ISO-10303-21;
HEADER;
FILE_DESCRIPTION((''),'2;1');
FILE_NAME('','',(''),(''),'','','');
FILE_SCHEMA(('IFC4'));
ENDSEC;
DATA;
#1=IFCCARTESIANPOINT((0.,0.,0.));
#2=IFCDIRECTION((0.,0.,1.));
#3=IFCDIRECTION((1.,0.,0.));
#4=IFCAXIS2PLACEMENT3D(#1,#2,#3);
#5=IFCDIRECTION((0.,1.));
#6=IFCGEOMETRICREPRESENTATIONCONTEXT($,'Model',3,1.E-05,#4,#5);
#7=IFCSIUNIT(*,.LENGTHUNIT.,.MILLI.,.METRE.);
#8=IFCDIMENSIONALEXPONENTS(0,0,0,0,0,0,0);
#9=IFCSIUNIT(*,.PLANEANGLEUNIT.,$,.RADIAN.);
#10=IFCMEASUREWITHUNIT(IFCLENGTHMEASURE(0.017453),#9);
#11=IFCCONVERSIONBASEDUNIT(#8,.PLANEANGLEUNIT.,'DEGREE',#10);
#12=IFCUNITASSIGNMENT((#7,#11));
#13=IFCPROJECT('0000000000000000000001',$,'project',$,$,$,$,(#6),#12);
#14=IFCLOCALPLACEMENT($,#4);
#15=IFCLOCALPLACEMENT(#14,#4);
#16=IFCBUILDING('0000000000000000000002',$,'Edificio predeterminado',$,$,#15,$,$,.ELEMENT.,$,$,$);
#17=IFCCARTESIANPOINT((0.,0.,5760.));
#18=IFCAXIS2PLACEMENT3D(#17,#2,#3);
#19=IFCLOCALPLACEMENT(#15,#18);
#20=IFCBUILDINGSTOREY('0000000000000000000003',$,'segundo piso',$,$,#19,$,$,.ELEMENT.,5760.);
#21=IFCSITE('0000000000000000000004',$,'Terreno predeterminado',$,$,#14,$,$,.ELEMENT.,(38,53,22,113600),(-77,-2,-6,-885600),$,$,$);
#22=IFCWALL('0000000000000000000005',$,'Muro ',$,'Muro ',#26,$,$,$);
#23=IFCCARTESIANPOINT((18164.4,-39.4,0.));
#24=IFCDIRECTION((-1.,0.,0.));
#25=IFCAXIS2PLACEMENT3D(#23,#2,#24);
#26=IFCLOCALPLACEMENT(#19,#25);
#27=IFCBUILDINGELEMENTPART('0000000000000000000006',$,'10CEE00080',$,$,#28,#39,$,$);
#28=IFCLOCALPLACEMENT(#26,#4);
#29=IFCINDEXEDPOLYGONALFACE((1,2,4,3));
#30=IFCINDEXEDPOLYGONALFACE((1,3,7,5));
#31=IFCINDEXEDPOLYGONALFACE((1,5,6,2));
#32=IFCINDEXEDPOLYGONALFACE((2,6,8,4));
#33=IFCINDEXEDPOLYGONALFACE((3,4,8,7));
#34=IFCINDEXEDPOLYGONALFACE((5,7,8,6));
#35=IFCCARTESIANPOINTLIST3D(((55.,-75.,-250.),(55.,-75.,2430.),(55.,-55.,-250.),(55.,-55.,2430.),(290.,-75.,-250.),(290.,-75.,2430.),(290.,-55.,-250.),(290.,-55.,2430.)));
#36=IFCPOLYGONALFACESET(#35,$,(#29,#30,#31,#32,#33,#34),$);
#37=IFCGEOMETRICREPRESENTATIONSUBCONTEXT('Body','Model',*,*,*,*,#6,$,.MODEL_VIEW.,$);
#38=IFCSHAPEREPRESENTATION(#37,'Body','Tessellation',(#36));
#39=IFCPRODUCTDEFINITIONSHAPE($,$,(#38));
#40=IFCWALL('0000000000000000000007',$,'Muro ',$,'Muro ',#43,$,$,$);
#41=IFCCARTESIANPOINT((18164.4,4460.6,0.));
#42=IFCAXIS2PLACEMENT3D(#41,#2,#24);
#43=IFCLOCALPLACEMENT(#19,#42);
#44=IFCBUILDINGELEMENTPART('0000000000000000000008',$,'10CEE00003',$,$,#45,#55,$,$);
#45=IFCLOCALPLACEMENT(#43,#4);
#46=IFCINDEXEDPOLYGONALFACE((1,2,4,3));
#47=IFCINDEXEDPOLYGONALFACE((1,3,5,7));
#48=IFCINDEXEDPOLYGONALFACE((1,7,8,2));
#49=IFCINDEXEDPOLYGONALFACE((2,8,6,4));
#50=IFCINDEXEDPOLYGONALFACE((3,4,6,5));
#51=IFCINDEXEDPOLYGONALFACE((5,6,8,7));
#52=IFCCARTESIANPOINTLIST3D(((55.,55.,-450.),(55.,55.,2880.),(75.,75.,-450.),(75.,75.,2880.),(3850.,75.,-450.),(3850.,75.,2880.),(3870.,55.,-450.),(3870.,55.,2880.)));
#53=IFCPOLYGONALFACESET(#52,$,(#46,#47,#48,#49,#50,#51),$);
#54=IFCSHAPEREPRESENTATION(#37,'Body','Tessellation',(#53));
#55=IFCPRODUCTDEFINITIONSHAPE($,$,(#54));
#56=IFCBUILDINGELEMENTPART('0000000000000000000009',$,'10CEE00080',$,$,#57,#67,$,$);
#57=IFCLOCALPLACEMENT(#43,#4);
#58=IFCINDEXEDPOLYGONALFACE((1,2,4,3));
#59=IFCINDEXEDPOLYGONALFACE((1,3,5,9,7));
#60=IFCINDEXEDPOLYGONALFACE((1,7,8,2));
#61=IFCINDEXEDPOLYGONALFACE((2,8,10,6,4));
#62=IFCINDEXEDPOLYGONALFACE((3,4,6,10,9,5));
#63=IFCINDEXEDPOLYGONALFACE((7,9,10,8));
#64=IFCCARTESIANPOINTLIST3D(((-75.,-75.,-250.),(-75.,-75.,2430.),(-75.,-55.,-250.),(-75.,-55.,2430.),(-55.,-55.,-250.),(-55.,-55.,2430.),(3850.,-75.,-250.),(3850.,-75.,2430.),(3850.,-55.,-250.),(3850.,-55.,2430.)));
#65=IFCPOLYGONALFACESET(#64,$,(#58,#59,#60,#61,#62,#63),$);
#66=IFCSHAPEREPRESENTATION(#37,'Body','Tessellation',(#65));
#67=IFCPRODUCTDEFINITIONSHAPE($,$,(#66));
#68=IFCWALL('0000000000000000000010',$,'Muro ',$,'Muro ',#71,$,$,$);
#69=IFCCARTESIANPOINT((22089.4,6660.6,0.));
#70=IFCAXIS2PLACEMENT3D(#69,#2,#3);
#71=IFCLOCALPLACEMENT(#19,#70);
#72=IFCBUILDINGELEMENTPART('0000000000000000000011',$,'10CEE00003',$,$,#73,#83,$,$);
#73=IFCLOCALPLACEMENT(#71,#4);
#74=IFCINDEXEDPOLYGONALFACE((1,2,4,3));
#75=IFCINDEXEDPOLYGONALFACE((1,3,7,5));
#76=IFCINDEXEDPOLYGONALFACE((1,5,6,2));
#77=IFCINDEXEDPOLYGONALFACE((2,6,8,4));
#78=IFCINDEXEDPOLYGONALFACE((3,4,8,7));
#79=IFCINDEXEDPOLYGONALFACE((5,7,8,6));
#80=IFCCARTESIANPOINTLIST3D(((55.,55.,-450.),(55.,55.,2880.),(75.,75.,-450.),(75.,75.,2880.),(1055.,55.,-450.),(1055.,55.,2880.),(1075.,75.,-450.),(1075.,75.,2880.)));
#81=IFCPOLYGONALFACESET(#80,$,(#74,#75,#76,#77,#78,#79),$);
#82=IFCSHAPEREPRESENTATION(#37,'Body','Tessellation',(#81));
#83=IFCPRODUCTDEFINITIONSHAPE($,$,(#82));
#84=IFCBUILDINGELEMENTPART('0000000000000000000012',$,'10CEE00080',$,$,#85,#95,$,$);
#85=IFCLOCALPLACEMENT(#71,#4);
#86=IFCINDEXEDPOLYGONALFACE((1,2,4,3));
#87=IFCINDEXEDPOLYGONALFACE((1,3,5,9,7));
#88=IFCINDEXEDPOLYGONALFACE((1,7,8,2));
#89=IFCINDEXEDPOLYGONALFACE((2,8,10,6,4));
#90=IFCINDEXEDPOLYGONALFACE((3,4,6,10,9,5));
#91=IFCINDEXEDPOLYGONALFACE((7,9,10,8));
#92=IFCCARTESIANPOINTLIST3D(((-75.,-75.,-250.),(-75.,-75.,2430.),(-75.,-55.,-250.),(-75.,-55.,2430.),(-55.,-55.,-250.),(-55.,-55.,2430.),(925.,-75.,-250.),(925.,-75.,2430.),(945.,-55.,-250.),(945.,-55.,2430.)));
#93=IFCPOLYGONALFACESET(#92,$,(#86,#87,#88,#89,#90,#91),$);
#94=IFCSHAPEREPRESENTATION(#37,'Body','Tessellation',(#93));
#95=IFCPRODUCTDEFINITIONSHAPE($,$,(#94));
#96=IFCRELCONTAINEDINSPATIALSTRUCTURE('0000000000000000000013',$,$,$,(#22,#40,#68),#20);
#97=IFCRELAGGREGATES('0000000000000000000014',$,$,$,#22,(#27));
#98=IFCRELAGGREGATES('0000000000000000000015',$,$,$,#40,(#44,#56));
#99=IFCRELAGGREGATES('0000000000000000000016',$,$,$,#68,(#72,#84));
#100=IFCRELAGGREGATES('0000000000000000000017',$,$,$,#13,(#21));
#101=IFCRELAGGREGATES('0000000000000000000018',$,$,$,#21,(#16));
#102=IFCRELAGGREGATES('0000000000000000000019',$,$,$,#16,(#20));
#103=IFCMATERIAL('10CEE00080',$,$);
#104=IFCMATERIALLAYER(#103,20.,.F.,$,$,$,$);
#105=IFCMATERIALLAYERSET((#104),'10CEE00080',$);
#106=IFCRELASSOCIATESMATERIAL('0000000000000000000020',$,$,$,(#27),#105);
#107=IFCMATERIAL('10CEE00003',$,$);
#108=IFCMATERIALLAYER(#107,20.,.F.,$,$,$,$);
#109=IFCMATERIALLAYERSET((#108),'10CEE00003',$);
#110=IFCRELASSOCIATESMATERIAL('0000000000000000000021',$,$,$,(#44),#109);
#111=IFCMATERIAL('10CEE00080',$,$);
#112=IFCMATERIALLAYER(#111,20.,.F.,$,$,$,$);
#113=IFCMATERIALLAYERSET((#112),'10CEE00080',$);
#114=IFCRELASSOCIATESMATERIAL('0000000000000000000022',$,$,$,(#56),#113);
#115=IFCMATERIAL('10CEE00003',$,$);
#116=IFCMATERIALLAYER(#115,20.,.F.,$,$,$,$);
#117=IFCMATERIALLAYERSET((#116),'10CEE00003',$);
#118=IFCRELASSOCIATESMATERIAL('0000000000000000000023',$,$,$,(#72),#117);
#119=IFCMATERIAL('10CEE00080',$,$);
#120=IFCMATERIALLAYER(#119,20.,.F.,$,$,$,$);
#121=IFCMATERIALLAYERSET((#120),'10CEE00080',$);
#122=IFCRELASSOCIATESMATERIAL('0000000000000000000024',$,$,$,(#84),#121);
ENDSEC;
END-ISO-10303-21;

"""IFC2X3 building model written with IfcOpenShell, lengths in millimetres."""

from ifc_helpers import new_model, entity, si_unit, converted_unit, direction, frame, origin_with_axes, place, context, subcontext, project, spatial, polyline, outline, extrude, material, layer, layer_set, layer_usage, element, aggregate, save


model = new_model("IFC2X3")

# Units and contexts
model_context = context("Model", 3, precision=1e-05, world=origin_with_axes(), true_north=direction((0.0, 1.0)))
body_context = subcontext(model_context, "Body", "Model", "MODEL_VIEW")
ifc_project = project(units=[si_unit("LENGTHUNIT", "METRE", prefix="MILLI"), converted_unit("PLANEANGLEUNIT", "DEGREE", entity("IfcLengthMeasure", 0.017453), si_unit("PLANEANGLEUNIT", "RADIAN"), dimensions=[0, 0, 0, 0, 0, 0, 0])], contexts=[model_context])

# Site, building, storey
site_placement = place(None, origin_with_axes())
site = spatial("IfcSite", under=ifc_project, at=site_placement, Name="Terreno predeterminado", CompositionType="ELEMENT", RefLatitude=(38, 53, 22, 113600), RefLongitude=(-77, -2, -6, -885600))
building_placement = place(site_placement, origin_with_axes())
building = spatial("IfcBuilding", under=site, at=building_placement, Name="Edificio predeterminado", CompositionType="ELEMENT")
storey_placement = place(building_placement, frame((0.0, 0.0, 5760.0), z_axis=(0.0, 0.0, 1.0), x_axis=(1.0, 0.0, 0.0)))
storey = spatial("IfcBuildingStorey", under=building, at=storey_placement, Name="segundo piso", CompositionType="ELEMENT", Elevation=5760.0)

# Wall, building element part
wall_1_placement = place(storey_placement, frame((18164.4, -39.4, 0.0), z_axis=(0.0, 0.0, 1.0), x_axis=(-1.0, 0.0, 0.0)))
wall_1 = element("IfcWall", 1, at=wall_1_placement, inside=storey, Name="Muro ", ObjectType="Muro ")
ifc_material_1 = material(Name="10CEE00080")
ifc_layer_1 = layer(ifc_material_1, 20.0, ventilated=False)
ifc_layer_set_1 = layer_set([ifc_layer_1], Name="10CEE00080")
ifc_layer_usage_1 = layer_usage(ifc_layer_set_1, "AXIS2", "NEGATIVE", 55.0)
building_element_part_1_placement = place(wall_1_placement, origin_with_axes())
building_element_part_1 = element("IfcBuildingElementPart", 2, at=building_element_part_1_placement, material=ifc_layer_usage_1, Name="10CEE00080", context=body_context, shape_type="SweptSolid", body=[
    extrude(outline(polyline([(290.0, -55.0), (290.0, -75.0), (55.0, -75.0), (55.0, -55.0), (290.0, -55.0)])), frame((0.0, 0.0, -250.0), z_axis=(0.0, 0.0, 1.0), x_axis=(1.0, 0.0, 0.0)), (0.0, 0.0, 1.0), 2680.0),
])
aggregate(wall_1, [building_element_part_1])

# Walls, building element parts
wall_2_placement = place(storey_placement, frame((18164.4, 4460.6, 0.0), z_axis=(0.0, 0.0, 1.0), x_axis=(-1.0, 0.0, 0.0)))
wall_2 = element("IfcWall", 3, at=wall_2_placement, inside=storey, Name="Muro ", ObjectType="Muro ")
ifc_material_2 = material(Name="10CEE00003")
ifc_layer_2 = layer(ifc_material_2, 20.0, ventilated=False)
ifc_layer_set_2 = layer_set([ifc_layer_2], Name="10CEE00003")
ifc_layer_usage_2 = layer_usage(ifc_layer_set_2, "AXIS2", "NEGATIVE", -75.0)
building_element_part_2_placement = place(wall_2_placement, origin_with_axes())
building_element_part_2 = element("IfcBuildingElementPart", 4, at=building_element_part_2_placement, material=ifc_layer_usage_2, Name="10CEE00003", context=body_context, shape_type="SweptSolid", body=[
    extrude(outline(polyline([(3850.0, 75.0), (3870.0, 55.0), (55.0, 55.0), (75.0, 75.0), (3850.0, 75.0)])), frame((0.0, 0.0, -450.0), z_axis=(0.0, 0.0, 1.0), x_axis=(1.0, 0.0, 0.0)), (0.0, 0.0, 1.0), 3330.0),
])
ifc_material_3 = material(Name="10CEE00080")
ifc_layer_3 = layer(ifc_material_3, 20.0, ventilated=False)
ifc_layer_set_3 = layer_set([ifc_layer_3], Name="10CEE00080")
ifc_layer_usage_3 = layer_usage(ifc_layer_set_3, "AXIS2", "NEGATIVE", 55.0)
building_element_part_3_placement = place(wall_2_placement, origin_with_axes())
building_element_part_3 = element("IfcBuildingElementPart", 5, at=building_element_part_3_placement, material=ifc_layer_usage_3, Name="10CEE00080", context=body_context, shape_type="SweptSolid", body=[
    extrude(outline(polyline([(3850.0, -55.0), (3850.0, -75.0), (-75.0, -75.0), (-75.0, -55.0), (-55.0, -55.0), (3850.0, -55.0)])), frame((0.0, 0.0, -250.0), z_axis=(0.0, 0.0, 1.0), x_axis=(1.0, 0.0, 0.0)), (0.0, 0.0, 1.0), 2680.0),
])
aggregate(wall_2, [building_element_part_2, building_element_part_3])
wall_3_placement = place(storey_placement, frame((22089.4, 6660.6, 0.0), z_axis=(0.0, 0.0, 1.0), x_axis=(1.0, 0.0, 0.0)))
wall_3 = element("IfcWall", 6, at=wall_3_placement, inside=storey, Name="Muro ", ObjectType="Muro ")
ifc_material_4 = material(Name="10CEE00003")
ifc_layer_4 = layer(ifc_material_4, 20.0, ventilated=False)
ifc_layer_set_4 = layer_set([ifc_layer_4], Name="10CEE00003")
ifc_layer_usage_4 = layer_usage(ifc_layer_set_4, "AXIS2", "NEGATIVE", -75.0)
building_element_part_4_placement = place(wall_3_placement, origin_with_axes())
building_element_part_4 = element("IfcBuildingElementPart", 7, at=building_element_part_4_placement, material=ifc_layer_usage_4, Name="10CEE00003", context=body_context, shape_type="SweptSolid", body=[
    extrude(outline(polyline([(1075.0, 75.0), (1055.0, 55.0), (55.0, 55.0), (75.0, 75.0), (1075.0, 75.0)])), frame((0.0, 0.0, -450.0), z_axis=(0.0, 0.0, 1.0), x_axis=(1.0, 0.0, 0.0)), (0.0, 0.0, 1.0), 3330.0),
])
ifc_material_5 = material(Name="10CEE00080")
ifc_layer_5 = layer(ifc_material_5, 20.0, ventilated=False)
ifc_layer_set_5 = layer_set([ifc_layer_5], Name="10CEE00080")
ifc_layer_usage_5 = layer_usage(ifc_layer_set_5, "AXIS2", "NEGATIVE", 55.0)
building_element_part_5_placement = place(wall_3_placement, origin_with_axes())
building_element_part_5 = element("IfcBuildingElementPart", 8, at=building_element_part_5_placement, material=ifc_layer_usage_5, Name="10CEE00080", context=body_context, shape_type="SweptSolid", body=[
    extrude(outline(polyline([(945.0, -55.0), (925.0, -75.0), (-75.0, -75.0), (-75.0, -55.0), (-55.0, -55.0), (945.0, -55.0)])), frame((0.0, 0.0, -250.0), z_axis=(0.0, 0.0, 1.0), x_axis=(1.0, 0.0, 0.0)), (0.0, 0.0, 1.0), 2680.0),
])
aggregate(wall_3, [building_element_part_4, building_element_part_5])

save(model, "model.ifc")
